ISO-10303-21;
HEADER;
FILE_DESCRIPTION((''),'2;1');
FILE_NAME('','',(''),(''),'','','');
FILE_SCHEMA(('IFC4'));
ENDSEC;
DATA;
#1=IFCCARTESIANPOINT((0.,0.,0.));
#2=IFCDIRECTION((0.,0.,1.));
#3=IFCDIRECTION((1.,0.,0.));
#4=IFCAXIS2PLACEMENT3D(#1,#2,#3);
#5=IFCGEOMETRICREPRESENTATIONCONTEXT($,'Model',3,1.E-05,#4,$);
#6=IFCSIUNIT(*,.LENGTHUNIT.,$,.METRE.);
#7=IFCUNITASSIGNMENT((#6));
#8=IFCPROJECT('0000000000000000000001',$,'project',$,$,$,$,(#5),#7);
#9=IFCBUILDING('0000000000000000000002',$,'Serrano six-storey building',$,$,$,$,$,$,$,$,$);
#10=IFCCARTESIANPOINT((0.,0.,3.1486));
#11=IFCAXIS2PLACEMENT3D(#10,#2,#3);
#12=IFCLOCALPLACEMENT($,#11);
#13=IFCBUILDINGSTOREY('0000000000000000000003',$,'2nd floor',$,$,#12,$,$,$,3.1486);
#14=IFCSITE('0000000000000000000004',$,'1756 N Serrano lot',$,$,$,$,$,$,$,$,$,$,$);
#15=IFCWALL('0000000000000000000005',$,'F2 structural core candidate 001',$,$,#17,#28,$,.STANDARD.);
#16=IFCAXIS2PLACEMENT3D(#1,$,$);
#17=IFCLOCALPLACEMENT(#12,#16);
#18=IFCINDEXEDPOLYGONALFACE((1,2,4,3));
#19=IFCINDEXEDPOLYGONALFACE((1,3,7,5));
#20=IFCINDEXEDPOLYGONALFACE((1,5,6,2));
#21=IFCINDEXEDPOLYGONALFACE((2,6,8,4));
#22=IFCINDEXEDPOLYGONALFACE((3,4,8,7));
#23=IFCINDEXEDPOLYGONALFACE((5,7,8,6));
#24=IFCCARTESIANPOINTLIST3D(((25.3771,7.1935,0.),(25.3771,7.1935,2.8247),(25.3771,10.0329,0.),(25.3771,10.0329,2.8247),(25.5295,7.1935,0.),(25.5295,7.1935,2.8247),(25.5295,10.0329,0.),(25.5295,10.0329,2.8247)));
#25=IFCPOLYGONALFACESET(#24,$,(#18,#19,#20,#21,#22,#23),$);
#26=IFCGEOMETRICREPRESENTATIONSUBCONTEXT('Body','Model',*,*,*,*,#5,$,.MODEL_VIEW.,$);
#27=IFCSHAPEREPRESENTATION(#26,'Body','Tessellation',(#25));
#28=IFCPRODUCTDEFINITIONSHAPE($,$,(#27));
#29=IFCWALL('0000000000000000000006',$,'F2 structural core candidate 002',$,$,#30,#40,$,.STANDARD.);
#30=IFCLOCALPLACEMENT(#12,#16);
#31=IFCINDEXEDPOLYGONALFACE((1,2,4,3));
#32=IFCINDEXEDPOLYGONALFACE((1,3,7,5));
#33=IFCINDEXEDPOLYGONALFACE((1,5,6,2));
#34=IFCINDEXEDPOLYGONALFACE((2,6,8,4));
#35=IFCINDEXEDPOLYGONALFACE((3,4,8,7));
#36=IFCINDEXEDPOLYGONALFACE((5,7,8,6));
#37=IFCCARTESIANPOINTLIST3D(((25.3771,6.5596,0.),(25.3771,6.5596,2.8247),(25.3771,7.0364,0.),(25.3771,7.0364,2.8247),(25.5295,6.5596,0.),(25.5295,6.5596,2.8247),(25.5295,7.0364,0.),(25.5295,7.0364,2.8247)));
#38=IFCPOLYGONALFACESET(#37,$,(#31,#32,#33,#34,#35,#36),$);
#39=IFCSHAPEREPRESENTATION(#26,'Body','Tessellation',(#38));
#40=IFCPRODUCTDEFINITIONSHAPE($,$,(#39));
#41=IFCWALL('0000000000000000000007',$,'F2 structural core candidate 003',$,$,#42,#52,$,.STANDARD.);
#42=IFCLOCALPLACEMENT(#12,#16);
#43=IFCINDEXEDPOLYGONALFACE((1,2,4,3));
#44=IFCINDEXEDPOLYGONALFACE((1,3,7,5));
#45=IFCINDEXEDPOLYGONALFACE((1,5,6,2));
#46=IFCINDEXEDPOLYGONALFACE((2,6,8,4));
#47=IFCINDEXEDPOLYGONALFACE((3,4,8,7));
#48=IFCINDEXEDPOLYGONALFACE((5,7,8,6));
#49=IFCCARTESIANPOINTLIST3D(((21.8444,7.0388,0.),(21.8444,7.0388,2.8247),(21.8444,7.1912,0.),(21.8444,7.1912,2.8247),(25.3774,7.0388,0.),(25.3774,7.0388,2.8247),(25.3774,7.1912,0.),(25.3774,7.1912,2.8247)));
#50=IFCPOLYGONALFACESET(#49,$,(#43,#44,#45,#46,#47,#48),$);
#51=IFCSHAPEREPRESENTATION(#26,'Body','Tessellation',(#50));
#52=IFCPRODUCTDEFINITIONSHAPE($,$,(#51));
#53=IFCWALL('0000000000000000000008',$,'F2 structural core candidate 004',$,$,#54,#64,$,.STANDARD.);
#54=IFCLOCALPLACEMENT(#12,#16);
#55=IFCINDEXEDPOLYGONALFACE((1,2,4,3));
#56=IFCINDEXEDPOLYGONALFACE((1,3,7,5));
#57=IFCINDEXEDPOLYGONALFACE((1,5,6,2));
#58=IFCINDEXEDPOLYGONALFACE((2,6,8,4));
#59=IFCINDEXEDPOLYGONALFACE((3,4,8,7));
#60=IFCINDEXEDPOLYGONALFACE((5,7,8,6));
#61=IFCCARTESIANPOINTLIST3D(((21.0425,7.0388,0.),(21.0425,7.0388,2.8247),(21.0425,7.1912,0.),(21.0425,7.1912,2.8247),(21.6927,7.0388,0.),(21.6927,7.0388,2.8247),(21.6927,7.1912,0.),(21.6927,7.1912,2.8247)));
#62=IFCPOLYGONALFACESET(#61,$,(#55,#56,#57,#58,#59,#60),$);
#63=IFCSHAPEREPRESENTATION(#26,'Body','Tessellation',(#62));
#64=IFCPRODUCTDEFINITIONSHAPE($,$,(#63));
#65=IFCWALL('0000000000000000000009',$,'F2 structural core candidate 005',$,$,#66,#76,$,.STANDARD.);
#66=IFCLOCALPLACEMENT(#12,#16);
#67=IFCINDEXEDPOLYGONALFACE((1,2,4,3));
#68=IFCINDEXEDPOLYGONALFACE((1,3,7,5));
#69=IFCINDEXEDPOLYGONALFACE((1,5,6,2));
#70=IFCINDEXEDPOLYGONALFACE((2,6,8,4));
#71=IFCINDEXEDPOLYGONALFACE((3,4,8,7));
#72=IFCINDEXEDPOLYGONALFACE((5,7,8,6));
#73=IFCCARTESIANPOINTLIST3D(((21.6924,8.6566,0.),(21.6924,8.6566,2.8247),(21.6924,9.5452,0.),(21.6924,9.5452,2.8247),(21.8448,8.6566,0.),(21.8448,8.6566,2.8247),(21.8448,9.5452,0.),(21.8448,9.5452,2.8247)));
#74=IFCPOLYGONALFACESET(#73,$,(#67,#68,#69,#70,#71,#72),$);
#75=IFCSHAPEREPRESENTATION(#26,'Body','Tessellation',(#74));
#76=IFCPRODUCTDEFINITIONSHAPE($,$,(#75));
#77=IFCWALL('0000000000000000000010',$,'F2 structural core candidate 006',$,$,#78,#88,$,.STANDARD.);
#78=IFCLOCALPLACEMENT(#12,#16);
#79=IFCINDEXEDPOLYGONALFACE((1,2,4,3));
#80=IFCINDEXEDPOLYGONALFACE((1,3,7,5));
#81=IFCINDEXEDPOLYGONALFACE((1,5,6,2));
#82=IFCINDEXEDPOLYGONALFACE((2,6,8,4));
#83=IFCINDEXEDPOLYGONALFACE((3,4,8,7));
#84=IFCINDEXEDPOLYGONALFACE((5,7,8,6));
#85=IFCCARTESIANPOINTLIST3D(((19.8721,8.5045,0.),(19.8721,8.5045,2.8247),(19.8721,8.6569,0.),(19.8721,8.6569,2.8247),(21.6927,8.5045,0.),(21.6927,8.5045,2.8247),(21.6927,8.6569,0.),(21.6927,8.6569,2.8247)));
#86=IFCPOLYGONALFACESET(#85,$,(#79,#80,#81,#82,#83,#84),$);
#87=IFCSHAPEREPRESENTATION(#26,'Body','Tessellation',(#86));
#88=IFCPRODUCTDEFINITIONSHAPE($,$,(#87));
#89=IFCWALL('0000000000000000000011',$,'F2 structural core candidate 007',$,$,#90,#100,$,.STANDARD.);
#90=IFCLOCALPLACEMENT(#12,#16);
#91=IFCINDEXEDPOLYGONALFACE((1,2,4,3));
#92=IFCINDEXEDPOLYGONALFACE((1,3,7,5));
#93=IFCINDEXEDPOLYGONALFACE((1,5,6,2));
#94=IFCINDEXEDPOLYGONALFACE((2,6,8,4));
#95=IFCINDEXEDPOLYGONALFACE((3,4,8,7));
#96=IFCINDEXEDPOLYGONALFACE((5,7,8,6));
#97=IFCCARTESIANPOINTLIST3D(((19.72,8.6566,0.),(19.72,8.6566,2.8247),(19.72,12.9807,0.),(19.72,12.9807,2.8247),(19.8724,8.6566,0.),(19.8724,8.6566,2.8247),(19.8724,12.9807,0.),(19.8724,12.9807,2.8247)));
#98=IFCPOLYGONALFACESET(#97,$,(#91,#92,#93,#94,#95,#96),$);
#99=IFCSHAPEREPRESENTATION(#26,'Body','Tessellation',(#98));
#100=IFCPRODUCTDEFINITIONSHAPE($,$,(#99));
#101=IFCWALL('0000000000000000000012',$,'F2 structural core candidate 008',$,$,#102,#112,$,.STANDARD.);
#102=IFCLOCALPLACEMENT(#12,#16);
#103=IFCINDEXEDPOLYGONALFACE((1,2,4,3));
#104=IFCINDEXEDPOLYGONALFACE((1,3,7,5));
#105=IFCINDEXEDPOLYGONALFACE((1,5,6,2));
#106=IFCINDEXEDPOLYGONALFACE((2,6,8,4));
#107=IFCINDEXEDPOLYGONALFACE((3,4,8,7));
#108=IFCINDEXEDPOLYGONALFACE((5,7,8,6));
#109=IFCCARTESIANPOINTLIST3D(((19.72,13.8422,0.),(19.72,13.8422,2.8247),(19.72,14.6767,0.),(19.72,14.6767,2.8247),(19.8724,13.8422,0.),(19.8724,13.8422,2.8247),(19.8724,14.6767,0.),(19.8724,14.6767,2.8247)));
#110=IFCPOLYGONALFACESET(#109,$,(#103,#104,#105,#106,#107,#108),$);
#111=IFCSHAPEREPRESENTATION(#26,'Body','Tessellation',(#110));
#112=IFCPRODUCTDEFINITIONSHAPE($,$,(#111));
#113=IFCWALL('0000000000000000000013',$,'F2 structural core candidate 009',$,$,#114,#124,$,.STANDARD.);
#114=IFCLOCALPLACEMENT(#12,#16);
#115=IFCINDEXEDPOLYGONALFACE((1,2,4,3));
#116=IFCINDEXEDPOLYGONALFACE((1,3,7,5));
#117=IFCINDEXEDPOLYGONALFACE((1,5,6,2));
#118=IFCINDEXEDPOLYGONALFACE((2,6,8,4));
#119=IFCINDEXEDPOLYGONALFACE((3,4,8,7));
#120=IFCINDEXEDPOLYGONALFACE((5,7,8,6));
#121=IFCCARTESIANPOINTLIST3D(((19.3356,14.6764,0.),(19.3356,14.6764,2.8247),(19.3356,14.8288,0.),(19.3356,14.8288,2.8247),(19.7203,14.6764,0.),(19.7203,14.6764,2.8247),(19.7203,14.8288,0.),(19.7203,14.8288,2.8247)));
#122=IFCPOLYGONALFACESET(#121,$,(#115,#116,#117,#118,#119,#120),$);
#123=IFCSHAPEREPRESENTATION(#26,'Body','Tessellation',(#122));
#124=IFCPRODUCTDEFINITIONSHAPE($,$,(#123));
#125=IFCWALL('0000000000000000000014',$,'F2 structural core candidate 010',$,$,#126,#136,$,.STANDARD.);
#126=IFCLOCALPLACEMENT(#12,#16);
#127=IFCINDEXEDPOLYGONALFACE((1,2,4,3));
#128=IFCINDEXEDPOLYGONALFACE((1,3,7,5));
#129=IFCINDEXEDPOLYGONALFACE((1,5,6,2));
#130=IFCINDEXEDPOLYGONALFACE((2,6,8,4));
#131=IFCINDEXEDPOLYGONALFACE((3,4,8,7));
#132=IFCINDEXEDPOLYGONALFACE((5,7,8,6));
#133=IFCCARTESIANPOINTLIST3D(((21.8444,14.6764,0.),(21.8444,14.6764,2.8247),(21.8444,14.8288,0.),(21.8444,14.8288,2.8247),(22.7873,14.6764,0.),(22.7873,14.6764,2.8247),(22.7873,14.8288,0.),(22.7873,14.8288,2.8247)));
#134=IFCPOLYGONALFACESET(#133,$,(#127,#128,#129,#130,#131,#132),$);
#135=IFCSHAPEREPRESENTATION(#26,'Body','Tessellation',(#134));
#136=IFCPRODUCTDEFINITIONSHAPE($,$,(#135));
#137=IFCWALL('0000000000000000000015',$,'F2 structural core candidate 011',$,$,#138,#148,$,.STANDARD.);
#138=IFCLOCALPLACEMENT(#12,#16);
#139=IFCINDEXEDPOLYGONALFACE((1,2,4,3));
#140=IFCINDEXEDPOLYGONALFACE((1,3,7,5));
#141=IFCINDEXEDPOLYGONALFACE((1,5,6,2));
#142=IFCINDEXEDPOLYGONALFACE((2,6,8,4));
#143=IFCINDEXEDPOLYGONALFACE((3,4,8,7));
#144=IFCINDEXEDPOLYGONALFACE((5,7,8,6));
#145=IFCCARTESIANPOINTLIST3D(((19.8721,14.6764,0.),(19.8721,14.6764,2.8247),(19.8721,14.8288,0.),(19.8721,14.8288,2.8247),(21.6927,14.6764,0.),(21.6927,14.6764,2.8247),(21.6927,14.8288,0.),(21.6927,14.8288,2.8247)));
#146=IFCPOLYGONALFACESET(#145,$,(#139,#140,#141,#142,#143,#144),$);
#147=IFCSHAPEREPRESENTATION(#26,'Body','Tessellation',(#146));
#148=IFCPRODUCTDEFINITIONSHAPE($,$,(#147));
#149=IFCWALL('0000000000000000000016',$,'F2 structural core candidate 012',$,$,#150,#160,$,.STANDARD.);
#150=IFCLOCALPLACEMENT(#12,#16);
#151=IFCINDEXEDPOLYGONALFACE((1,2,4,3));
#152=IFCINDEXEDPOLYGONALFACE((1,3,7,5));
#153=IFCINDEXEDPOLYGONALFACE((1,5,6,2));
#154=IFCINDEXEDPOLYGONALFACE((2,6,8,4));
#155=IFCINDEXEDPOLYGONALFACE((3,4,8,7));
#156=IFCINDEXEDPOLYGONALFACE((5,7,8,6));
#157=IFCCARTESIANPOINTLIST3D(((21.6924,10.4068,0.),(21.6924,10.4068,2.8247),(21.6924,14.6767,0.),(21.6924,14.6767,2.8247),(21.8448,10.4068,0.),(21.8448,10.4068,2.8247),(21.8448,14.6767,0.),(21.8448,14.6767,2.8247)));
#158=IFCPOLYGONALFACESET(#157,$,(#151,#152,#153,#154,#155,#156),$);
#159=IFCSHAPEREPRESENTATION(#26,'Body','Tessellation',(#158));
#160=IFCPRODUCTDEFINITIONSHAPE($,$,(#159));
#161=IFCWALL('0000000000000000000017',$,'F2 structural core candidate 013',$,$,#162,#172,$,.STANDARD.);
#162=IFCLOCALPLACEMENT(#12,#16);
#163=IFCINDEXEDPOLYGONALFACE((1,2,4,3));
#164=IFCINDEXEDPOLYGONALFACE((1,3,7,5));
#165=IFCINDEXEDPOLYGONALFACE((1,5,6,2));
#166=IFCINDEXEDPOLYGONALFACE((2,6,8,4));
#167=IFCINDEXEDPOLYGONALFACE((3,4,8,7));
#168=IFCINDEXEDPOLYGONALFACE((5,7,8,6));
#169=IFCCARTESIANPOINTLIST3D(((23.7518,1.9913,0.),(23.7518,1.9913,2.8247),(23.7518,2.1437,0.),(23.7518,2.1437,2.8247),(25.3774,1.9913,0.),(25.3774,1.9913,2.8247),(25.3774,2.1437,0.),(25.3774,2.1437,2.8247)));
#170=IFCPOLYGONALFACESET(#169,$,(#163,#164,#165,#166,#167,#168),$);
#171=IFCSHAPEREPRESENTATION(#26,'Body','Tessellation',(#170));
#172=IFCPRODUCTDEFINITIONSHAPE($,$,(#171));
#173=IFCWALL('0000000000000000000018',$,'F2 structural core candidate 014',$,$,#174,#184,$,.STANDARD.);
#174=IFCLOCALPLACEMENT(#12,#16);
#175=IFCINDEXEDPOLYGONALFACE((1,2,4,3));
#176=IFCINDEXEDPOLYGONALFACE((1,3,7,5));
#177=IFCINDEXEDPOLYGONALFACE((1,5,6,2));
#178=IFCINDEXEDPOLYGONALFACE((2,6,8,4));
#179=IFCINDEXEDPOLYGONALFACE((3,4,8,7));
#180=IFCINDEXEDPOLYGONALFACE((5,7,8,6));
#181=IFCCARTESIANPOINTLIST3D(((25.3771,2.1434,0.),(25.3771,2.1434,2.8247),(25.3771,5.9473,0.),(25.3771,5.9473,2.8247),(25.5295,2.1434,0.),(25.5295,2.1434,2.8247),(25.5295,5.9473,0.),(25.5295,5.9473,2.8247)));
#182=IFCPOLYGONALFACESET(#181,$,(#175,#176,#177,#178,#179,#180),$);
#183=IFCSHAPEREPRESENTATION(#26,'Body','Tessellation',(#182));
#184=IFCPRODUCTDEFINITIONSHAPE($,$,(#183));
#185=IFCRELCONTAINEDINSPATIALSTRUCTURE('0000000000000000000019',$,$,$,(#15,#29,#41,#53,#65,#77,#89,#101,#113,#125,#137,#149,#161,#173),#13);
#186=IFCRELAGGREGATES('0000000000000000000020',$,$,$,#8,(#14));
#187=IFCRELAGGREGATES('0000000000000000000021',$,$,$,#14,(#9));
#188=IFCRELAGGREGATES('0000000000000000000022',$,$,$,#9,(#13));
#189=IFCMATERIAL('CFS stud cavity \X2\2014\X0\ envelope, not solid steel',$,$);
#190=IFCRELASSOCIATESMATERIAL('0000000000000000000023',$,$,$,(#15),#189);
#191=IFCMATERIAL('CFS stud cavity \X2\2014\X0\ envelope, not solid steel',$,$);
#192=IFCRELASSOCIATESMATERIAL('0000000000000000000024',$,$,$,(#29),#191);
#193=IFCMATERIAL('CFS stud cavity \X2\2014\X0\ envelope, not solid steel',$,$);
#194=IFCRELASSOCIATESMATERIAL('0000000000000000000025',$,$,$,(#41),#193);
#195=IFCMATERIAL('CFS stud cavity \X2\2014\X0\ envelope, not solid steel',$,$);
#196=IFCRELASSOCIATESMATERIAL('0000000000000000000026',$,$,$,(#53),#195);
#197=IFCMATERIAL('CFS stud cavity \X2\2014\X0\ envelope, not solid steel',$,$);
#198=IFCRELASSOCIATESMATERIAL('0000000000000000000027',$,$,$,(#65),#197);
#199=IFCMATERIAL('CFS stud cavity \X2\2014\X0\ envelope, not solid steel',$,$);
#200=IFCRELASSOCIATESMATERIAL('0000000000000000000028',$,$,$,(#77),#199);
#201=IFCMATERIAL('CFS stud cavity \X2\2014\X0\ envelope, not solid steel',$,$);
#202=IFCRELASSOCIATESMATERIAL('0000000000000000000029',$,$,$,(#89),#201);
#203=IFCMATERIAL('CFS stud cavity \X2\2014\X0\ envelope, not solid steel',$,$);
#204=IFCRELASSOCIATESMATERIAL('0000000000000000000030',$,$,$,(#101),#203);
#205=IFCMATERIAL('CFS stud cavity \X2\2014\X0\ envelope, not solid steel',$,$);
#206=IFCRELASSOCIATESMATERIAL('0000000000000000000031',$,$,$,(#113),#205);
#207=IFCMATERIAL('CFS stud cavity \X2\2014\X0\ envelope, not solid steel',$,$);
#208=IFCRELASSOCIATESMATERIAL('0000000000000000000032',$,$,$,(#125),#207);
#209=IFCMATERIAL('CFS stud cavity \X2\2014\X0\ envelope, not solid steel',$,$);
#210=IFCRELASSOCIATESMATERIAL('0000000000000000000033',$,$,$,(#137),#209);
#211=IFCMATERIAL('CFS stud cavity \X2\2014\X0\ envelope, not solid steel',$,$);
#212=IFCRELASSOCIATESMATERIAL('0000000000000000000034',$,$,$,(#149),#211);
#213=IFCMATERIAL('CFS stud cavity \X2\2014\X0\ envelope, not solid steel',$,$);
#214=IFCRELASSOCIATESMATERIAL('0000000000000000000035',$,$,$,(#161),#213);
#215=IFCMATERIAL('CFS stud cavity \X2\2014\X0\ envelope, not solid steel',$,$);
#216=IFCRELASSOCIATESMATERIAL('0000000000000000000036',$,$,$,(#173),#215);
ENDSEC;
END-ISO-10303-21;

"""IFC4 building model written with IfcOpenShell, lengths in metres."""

from ifc_helpers import new_model, si_unit, frame, origin_with_axes, place, context, subcontext, project, spatial, polyline, outline, extrude, material, element, save


model = new_model("IFC4")

# Units and contexts
model_context = context("Model", 3, precision=1e-05, world=origin_with_axes())
body_context = subcontext(model_context, "Body", "Model", "MODEL_VIEW")
ifc_project = project(units=[si_unit("LENGTHUNIT", "METRE")], contexts=[model_context])

# Site, building, storey
site = spatial("IfcSite", under=ifc_project, Name="1756 N Serrano lot")
building = spatial("IfcBuilding", under=site, Name="Serrano six-storey building")
storey_placement = place(None, frame((0.0, 0.0, 3.1486), z_axis=(0.0, 0.0, 1.0), x_axis=(1.0, 0.0, 0.0)))
storey = spatial("IfcBuildingStorey", under=building, at=storey_placement, Name="2nd floor", Elevation=3.1486)

# Walls
ifc_material_1 = material(Name="CFS stud cavity — envelope, not solid steel")
wall_1_placement = place(storey_placement, frame((0.0, 0.0, -3.1486), z_axis=(0.0, 0.0, 1.0), x_axis=(1.0, 0.0, 0.0)))
element("IfcWall", 1, at=wall_1_placement, inside=storey, material=ifc_material_1, Name="F2 structural core candidate 001", PredefinedType="STANDARD", context=body_context, shape_type="SweptSolid", body=[
    extrude(outline(polyline([(25.5295, 7.1935), (25.3771, 7.1935), (25.3771, 10.0329), (25.5295, 10.0329), (25.5295, 7.1935)])), frame((0.0, 0.0, 3.1486)), (0.0, 0.0, 1.0), 2.8247),
])
ifc_material_2 = material(Name="CFS stud cavity — envelope, not solid steel")
wall_2_placement = place(storey_placement, frame((0.0, 0.0, -3.1486), z_axis=(0.0, 0.0, 1.0), x_axis=(1.0, 0.0, 0.0)))
element("IfcWall", 2, at=wall_2_placement, inside=storey, material=ifc_material_2, Name="F2 structural core candidate 002", PredefinedType="STANDARD", context=body_context, shape_type="SweptSolid", body=[
    extrude(outline(polyline([(25.5295, 6.5596), (25.3771, 6.5596), (25.3771, 7.0364), (25.5295, 7.0364), (25.5295, 6.5596)])), frame((0.0, 0.0, 3.1486)), (0.0, 0.0, 1.0), 2.8247),
])
ifc_material_3 = material(Name="CFS stud cavity — envelope, not solid steel")
wall_3_placement = place(storey_placement, frame((0.0, 0.0, -3.1486), z_axis=(0.0, 0.0, 1.0), x_axis=(1.0, 0.0, 0.0)))
element("IfcWall", 3, at=wall_3_placement, inside=storey, material=ifc_material_3, Name="F2 structural core candidate 003", PredefinedType="STANDARD", context=body_context, shape_type="SweptSolid", body=[
    extrude(outline(polyline([(25.3774, 7.1912), (25.3774, 7.0388), (21.8444, 7.0388), (21.8444, 7.1912), (25.3774, 7.1912)])), frame((0.0, 0.0, 3.1486)), (0.0, 0.0, 1.0), 2.8247),
])
ifc_material_4 = material(Name="CFS stud cavity — envelope, not solid steel")
wall_4_placement = place(storey_placement, frame((0.0, 0.0, -3.1486), z_axis=(0.0, 0.0, 1.0), x_axis=(1.0, 0.0, 0.0)))
element("IfcWall", 4, at=wall_4_placement, inside=storey, material=ifc_material_4, Name="F2 structural core candidate 004", PredefinedType="STANDARD", context=body_context, shape_type="SweptSolid", body=[
    extrude(outline(polyline([(21.6927, 7.1912), (21.6927, 7.0388), (21.0425, 7.0388), (21.0425, 7.1912), (21.6927, 7.1912)])), frame((0.0, 0.0, 3.1486)), (0.0, 0.0, 1.0), 2.8247),
])
ifc_material_5 = material(Name="CFS stud cavity — envelope, not solid steel")
wall_5_placement = place(storey_placement, frame((0.0, 0.0, -3.1486), z_axis=(0.0, 0.0, 1.0), x_axis=(1.0, 0.0, 0.0)))
element("IfcWall", 5, at=wall_5_placement, inside=storey, material=ifc_material_5, Name="F2 structural core candidate 005", PredefinedType="STANDARD", context=body_context, shape_type="SweptSolid", body=[
    extrude(outline(polyline([(21.8448, 8.6566), (21.6924, 8.6566), (21.6924, 9.5452), (21.8448, 9.5452), (21.8448, 8.6566)])), frame((0.0, 0.0, 3.1486)), (0.0, 0.0, 1.0), 2.8247),
])
ifc_material_6 = material(Name="CFS stud cavity — envelope, not solid steel")
wall_6_placement = place(storey_placement, frame((0.0, 0.0, -3.1486), z_axis=(0.0, 0.0, 1.0), x_axis=(1.0, 0.0, 0.0)))
element("IfcWall", 6, at=wall_6_placement, inside=storey, material=ifc_material_6, Name="F2 structural core candidate 006", PredefinedType="STANDARD", context=body_context, shape_type="SweptSolid", body=[
    extrude(outline(polyline([(21.6927, 8.6569), (21.6927, 8.5045), (19.8721, 8.5045), (19.8721, 8.6569), (21.6927, 8.6569)])), frame((0.0, 0.0, 3.1486)), (0.0, 0.0, 1.0), 2.8247),
])
ifc_material_7 = material(Name="CFS stud cavity — envelope, not solid steel")
wall_7_placement = place(storey_placement, frame((0.0, 0.0, -3.1486), z_axis=(0.0, 0.0, 1.0), x_axis=(1.0, 0.0, 0.0)))
element("IfcWall", 7, at=wall_7_placement, inside=storey, material=ifc_material_7, Name="F2 structural core candidate 007", PredefinedType="STANDARD", context=body_context, shape_type="SweptSolid", body=[
    extrude(outline(polyline([(19.8724, 8.6566), (19.72, 8.6566), (19.72, 12.9807), (19.8724, 12.9807), (19.8724, 8.6566)])), frame((0.0, 0.0, 3.1486)), (0.0, 0.0, 1.0), 2.8247),
])
ifc_material_8 = material(Name="CFS stud cavity — envelope, not solid steel")
wall_8_placement = place(storey_placement, frame((0.0, 0.0, -3.1486), z_axis=(0.0, 0.0, 1.0), x_axis=(1.0, 0.0, 0.0)))
element("IfcWall", 8, at=wall_8_placement, inside=storey, material=ifc_material_8, Name="F2 structural core candidate 008", PredefinedType="STANDARD", context=body_context, shape_type="SweptSolid", body=[
    extrude(outline(polyline([(19.8724, 13.8422), (19.72, 13.8422), (19.72, 14.6767), (19.8724, 14.6767), (19.8724, 13.8422)])), frame((0.0, 0.0, 3.1486)), (0.0, 0.0, 1.0), 2.8247),
])
ifc_material_9 = material(Name="CFS stud cavity — envelope, not solid steel")
wall_9_placement = place(storey_placement, frame((0.0, 0.0, -3.1486), z_axis=(0.0, 0.0, 1.0), x_axis=(1.0, 0.0, 0.0)))
element("IfcWall", 9, at=wall_9_placement, inside=storey, material=ifc_material_9, Name="F2 structural core candidate 009", PredefinedType="STANDARD", context=body_context, shape_type="SweptSolid", body=[
    extrude(outline(polyline([(19.7203, 14.8288), (19.7203, 14.6764), (19.3356, 14.6764), (19.3356, 14.8288), (19.7203, 14.8288)])), frame((0.0, 0.0, 3.1486)), (0.0, 0.0, 1.0), 2.8247),
])
ifc_material_10 = material(Name="CFS stud cavity — envelope, not solid steel")
wall_10_placement = place(storey_placement, frame((0.0, 0.0, -3.1486), z_axis=(0.0, 0.0, 1.0), x_axis=(1.0, 0.0, 0.0)))
element("IfcWall", 10, at=wall_10_placement, inside=storey, material=ifc_material_10, Name="F2 structural core candidate 010", PredefinedType="STANDARD", context=body_context, shape_type="SweptSolid", body=[
    extrude(outline(polyline([(22.7873, 14.8288), (22.7873, 14.6764), (21.8444, 14.6764), (21.8444, 14.8288), (22.7873, 14.8288)])), frame((0.0, 0.0, 3.1486)), (0.0, 0.0, 1.0), 2.8247),
])
ifc_material_11 = material(Name="CFS stud cavity — envelope, not solid steel")
wall_11_placement = place(storey_placement, frame((0.0, 0.0, -3.1486), z_axis=(0.0, 0.0, 1.0), x_axis=(1.0, 0.0, 0.0)))
element("IfcWall", 11, at=wall_11_placement, inside=storey, material=ifc_material_11, Name="F2 structural core candidate 011", PredefinedType="STANDARD", context=body_context, shape_type="SweptSolid", body=[
    extrude(outline(polyline([(21.6927, 14.8288), (21.6927, 14.6764), (19.8721, 14.6764), (19.8721, 14.8288), (21.6927, 14.8288)])), frame((0.0, 0.0, 3.1486)), (0.0, 0.0, 1.0), 2.8247),
])
ifc_material_12 = material(Name="CFS stud cavity — envelope, not solid steel")
wall_12_placement = place(storey_placement, frame((0.0, 0.0, -3.1486), z_axis=(0.0, 0.0, 1.0), x_axis=(1.0, 0.0, 0.0)))
element("IfcWall", 12, at=wall_12_placement, inside=storey, material=ifc_material_12, Name="F2 structural core candidate 012", PredefinedType="STANDARD", context=body_context, shape_type="SweptSolid", body=[
    extrude(outline(polyline([(21.8448, 10.4068), (21.6924, 10.4068), (21.6924, 14.6767), (21.8448, 14.6767), (21.8448, 10.4068)])), frame((0.0, 0.0, 3.1486)), (0.0, 0.0, 1.0), 2.8247),
])
ifc_material_13 = material(Name="CFS stud cavity — envelope, not solid steel")
wall_13_placement = place(storey_placement, frame((0.0, 0.0, -3.1486), z_axis=(0.0, 0.0, 1.0), x_axis=(1.0, 0.0, 0.0)))
element("IfcWall", 13, at=wall_13_placement, inside=storey, material=ifc_material_13, Name="F2 structural core candidate 013", PredefinedType="STANDARD", context=body_context, shape_type="SweptSolid", body=[
    extrude(outline(polyline([(25.3774, 2.1437), (25.3774, 1.9913), (23.7518, 1.9913), (23.7518, 2.1437), (25.3774, 2.1437)])), frame((0.0, 0.0, 3.1486)), (0.0, 0.0, 1.0), 2.8247),
])
ifc_material_14 = material(Name="CFS stud cavity — envelope, not solid steel")
wall_14_placement = place(storey_placement, frame((0.0, 0.0, -3.1486), z_axis=(0.0, 0.0, 1.0), x_axis=(1.0, 0.0, 0.0)))
element("IfcWall", 14, at=wall_14_placement, inside=storey, material=ifc_material_14, Name="F2 structural core candidate 014", PredefinedType="STANDARD", context=body_context, shape_type="SweptSolid", body=[
    extrude(outline(polyline([(25.5295, 2.1434), (25.3771, 2.1434), (25.3771, 5.9473), (25.5295, 5.9473), (25.5295, 2.1434)])), frame((0.0, 0.0, 3.1486)), (0.0, 0.0, 1.0), 2.8247),
])

save(model, "model.ifc")
